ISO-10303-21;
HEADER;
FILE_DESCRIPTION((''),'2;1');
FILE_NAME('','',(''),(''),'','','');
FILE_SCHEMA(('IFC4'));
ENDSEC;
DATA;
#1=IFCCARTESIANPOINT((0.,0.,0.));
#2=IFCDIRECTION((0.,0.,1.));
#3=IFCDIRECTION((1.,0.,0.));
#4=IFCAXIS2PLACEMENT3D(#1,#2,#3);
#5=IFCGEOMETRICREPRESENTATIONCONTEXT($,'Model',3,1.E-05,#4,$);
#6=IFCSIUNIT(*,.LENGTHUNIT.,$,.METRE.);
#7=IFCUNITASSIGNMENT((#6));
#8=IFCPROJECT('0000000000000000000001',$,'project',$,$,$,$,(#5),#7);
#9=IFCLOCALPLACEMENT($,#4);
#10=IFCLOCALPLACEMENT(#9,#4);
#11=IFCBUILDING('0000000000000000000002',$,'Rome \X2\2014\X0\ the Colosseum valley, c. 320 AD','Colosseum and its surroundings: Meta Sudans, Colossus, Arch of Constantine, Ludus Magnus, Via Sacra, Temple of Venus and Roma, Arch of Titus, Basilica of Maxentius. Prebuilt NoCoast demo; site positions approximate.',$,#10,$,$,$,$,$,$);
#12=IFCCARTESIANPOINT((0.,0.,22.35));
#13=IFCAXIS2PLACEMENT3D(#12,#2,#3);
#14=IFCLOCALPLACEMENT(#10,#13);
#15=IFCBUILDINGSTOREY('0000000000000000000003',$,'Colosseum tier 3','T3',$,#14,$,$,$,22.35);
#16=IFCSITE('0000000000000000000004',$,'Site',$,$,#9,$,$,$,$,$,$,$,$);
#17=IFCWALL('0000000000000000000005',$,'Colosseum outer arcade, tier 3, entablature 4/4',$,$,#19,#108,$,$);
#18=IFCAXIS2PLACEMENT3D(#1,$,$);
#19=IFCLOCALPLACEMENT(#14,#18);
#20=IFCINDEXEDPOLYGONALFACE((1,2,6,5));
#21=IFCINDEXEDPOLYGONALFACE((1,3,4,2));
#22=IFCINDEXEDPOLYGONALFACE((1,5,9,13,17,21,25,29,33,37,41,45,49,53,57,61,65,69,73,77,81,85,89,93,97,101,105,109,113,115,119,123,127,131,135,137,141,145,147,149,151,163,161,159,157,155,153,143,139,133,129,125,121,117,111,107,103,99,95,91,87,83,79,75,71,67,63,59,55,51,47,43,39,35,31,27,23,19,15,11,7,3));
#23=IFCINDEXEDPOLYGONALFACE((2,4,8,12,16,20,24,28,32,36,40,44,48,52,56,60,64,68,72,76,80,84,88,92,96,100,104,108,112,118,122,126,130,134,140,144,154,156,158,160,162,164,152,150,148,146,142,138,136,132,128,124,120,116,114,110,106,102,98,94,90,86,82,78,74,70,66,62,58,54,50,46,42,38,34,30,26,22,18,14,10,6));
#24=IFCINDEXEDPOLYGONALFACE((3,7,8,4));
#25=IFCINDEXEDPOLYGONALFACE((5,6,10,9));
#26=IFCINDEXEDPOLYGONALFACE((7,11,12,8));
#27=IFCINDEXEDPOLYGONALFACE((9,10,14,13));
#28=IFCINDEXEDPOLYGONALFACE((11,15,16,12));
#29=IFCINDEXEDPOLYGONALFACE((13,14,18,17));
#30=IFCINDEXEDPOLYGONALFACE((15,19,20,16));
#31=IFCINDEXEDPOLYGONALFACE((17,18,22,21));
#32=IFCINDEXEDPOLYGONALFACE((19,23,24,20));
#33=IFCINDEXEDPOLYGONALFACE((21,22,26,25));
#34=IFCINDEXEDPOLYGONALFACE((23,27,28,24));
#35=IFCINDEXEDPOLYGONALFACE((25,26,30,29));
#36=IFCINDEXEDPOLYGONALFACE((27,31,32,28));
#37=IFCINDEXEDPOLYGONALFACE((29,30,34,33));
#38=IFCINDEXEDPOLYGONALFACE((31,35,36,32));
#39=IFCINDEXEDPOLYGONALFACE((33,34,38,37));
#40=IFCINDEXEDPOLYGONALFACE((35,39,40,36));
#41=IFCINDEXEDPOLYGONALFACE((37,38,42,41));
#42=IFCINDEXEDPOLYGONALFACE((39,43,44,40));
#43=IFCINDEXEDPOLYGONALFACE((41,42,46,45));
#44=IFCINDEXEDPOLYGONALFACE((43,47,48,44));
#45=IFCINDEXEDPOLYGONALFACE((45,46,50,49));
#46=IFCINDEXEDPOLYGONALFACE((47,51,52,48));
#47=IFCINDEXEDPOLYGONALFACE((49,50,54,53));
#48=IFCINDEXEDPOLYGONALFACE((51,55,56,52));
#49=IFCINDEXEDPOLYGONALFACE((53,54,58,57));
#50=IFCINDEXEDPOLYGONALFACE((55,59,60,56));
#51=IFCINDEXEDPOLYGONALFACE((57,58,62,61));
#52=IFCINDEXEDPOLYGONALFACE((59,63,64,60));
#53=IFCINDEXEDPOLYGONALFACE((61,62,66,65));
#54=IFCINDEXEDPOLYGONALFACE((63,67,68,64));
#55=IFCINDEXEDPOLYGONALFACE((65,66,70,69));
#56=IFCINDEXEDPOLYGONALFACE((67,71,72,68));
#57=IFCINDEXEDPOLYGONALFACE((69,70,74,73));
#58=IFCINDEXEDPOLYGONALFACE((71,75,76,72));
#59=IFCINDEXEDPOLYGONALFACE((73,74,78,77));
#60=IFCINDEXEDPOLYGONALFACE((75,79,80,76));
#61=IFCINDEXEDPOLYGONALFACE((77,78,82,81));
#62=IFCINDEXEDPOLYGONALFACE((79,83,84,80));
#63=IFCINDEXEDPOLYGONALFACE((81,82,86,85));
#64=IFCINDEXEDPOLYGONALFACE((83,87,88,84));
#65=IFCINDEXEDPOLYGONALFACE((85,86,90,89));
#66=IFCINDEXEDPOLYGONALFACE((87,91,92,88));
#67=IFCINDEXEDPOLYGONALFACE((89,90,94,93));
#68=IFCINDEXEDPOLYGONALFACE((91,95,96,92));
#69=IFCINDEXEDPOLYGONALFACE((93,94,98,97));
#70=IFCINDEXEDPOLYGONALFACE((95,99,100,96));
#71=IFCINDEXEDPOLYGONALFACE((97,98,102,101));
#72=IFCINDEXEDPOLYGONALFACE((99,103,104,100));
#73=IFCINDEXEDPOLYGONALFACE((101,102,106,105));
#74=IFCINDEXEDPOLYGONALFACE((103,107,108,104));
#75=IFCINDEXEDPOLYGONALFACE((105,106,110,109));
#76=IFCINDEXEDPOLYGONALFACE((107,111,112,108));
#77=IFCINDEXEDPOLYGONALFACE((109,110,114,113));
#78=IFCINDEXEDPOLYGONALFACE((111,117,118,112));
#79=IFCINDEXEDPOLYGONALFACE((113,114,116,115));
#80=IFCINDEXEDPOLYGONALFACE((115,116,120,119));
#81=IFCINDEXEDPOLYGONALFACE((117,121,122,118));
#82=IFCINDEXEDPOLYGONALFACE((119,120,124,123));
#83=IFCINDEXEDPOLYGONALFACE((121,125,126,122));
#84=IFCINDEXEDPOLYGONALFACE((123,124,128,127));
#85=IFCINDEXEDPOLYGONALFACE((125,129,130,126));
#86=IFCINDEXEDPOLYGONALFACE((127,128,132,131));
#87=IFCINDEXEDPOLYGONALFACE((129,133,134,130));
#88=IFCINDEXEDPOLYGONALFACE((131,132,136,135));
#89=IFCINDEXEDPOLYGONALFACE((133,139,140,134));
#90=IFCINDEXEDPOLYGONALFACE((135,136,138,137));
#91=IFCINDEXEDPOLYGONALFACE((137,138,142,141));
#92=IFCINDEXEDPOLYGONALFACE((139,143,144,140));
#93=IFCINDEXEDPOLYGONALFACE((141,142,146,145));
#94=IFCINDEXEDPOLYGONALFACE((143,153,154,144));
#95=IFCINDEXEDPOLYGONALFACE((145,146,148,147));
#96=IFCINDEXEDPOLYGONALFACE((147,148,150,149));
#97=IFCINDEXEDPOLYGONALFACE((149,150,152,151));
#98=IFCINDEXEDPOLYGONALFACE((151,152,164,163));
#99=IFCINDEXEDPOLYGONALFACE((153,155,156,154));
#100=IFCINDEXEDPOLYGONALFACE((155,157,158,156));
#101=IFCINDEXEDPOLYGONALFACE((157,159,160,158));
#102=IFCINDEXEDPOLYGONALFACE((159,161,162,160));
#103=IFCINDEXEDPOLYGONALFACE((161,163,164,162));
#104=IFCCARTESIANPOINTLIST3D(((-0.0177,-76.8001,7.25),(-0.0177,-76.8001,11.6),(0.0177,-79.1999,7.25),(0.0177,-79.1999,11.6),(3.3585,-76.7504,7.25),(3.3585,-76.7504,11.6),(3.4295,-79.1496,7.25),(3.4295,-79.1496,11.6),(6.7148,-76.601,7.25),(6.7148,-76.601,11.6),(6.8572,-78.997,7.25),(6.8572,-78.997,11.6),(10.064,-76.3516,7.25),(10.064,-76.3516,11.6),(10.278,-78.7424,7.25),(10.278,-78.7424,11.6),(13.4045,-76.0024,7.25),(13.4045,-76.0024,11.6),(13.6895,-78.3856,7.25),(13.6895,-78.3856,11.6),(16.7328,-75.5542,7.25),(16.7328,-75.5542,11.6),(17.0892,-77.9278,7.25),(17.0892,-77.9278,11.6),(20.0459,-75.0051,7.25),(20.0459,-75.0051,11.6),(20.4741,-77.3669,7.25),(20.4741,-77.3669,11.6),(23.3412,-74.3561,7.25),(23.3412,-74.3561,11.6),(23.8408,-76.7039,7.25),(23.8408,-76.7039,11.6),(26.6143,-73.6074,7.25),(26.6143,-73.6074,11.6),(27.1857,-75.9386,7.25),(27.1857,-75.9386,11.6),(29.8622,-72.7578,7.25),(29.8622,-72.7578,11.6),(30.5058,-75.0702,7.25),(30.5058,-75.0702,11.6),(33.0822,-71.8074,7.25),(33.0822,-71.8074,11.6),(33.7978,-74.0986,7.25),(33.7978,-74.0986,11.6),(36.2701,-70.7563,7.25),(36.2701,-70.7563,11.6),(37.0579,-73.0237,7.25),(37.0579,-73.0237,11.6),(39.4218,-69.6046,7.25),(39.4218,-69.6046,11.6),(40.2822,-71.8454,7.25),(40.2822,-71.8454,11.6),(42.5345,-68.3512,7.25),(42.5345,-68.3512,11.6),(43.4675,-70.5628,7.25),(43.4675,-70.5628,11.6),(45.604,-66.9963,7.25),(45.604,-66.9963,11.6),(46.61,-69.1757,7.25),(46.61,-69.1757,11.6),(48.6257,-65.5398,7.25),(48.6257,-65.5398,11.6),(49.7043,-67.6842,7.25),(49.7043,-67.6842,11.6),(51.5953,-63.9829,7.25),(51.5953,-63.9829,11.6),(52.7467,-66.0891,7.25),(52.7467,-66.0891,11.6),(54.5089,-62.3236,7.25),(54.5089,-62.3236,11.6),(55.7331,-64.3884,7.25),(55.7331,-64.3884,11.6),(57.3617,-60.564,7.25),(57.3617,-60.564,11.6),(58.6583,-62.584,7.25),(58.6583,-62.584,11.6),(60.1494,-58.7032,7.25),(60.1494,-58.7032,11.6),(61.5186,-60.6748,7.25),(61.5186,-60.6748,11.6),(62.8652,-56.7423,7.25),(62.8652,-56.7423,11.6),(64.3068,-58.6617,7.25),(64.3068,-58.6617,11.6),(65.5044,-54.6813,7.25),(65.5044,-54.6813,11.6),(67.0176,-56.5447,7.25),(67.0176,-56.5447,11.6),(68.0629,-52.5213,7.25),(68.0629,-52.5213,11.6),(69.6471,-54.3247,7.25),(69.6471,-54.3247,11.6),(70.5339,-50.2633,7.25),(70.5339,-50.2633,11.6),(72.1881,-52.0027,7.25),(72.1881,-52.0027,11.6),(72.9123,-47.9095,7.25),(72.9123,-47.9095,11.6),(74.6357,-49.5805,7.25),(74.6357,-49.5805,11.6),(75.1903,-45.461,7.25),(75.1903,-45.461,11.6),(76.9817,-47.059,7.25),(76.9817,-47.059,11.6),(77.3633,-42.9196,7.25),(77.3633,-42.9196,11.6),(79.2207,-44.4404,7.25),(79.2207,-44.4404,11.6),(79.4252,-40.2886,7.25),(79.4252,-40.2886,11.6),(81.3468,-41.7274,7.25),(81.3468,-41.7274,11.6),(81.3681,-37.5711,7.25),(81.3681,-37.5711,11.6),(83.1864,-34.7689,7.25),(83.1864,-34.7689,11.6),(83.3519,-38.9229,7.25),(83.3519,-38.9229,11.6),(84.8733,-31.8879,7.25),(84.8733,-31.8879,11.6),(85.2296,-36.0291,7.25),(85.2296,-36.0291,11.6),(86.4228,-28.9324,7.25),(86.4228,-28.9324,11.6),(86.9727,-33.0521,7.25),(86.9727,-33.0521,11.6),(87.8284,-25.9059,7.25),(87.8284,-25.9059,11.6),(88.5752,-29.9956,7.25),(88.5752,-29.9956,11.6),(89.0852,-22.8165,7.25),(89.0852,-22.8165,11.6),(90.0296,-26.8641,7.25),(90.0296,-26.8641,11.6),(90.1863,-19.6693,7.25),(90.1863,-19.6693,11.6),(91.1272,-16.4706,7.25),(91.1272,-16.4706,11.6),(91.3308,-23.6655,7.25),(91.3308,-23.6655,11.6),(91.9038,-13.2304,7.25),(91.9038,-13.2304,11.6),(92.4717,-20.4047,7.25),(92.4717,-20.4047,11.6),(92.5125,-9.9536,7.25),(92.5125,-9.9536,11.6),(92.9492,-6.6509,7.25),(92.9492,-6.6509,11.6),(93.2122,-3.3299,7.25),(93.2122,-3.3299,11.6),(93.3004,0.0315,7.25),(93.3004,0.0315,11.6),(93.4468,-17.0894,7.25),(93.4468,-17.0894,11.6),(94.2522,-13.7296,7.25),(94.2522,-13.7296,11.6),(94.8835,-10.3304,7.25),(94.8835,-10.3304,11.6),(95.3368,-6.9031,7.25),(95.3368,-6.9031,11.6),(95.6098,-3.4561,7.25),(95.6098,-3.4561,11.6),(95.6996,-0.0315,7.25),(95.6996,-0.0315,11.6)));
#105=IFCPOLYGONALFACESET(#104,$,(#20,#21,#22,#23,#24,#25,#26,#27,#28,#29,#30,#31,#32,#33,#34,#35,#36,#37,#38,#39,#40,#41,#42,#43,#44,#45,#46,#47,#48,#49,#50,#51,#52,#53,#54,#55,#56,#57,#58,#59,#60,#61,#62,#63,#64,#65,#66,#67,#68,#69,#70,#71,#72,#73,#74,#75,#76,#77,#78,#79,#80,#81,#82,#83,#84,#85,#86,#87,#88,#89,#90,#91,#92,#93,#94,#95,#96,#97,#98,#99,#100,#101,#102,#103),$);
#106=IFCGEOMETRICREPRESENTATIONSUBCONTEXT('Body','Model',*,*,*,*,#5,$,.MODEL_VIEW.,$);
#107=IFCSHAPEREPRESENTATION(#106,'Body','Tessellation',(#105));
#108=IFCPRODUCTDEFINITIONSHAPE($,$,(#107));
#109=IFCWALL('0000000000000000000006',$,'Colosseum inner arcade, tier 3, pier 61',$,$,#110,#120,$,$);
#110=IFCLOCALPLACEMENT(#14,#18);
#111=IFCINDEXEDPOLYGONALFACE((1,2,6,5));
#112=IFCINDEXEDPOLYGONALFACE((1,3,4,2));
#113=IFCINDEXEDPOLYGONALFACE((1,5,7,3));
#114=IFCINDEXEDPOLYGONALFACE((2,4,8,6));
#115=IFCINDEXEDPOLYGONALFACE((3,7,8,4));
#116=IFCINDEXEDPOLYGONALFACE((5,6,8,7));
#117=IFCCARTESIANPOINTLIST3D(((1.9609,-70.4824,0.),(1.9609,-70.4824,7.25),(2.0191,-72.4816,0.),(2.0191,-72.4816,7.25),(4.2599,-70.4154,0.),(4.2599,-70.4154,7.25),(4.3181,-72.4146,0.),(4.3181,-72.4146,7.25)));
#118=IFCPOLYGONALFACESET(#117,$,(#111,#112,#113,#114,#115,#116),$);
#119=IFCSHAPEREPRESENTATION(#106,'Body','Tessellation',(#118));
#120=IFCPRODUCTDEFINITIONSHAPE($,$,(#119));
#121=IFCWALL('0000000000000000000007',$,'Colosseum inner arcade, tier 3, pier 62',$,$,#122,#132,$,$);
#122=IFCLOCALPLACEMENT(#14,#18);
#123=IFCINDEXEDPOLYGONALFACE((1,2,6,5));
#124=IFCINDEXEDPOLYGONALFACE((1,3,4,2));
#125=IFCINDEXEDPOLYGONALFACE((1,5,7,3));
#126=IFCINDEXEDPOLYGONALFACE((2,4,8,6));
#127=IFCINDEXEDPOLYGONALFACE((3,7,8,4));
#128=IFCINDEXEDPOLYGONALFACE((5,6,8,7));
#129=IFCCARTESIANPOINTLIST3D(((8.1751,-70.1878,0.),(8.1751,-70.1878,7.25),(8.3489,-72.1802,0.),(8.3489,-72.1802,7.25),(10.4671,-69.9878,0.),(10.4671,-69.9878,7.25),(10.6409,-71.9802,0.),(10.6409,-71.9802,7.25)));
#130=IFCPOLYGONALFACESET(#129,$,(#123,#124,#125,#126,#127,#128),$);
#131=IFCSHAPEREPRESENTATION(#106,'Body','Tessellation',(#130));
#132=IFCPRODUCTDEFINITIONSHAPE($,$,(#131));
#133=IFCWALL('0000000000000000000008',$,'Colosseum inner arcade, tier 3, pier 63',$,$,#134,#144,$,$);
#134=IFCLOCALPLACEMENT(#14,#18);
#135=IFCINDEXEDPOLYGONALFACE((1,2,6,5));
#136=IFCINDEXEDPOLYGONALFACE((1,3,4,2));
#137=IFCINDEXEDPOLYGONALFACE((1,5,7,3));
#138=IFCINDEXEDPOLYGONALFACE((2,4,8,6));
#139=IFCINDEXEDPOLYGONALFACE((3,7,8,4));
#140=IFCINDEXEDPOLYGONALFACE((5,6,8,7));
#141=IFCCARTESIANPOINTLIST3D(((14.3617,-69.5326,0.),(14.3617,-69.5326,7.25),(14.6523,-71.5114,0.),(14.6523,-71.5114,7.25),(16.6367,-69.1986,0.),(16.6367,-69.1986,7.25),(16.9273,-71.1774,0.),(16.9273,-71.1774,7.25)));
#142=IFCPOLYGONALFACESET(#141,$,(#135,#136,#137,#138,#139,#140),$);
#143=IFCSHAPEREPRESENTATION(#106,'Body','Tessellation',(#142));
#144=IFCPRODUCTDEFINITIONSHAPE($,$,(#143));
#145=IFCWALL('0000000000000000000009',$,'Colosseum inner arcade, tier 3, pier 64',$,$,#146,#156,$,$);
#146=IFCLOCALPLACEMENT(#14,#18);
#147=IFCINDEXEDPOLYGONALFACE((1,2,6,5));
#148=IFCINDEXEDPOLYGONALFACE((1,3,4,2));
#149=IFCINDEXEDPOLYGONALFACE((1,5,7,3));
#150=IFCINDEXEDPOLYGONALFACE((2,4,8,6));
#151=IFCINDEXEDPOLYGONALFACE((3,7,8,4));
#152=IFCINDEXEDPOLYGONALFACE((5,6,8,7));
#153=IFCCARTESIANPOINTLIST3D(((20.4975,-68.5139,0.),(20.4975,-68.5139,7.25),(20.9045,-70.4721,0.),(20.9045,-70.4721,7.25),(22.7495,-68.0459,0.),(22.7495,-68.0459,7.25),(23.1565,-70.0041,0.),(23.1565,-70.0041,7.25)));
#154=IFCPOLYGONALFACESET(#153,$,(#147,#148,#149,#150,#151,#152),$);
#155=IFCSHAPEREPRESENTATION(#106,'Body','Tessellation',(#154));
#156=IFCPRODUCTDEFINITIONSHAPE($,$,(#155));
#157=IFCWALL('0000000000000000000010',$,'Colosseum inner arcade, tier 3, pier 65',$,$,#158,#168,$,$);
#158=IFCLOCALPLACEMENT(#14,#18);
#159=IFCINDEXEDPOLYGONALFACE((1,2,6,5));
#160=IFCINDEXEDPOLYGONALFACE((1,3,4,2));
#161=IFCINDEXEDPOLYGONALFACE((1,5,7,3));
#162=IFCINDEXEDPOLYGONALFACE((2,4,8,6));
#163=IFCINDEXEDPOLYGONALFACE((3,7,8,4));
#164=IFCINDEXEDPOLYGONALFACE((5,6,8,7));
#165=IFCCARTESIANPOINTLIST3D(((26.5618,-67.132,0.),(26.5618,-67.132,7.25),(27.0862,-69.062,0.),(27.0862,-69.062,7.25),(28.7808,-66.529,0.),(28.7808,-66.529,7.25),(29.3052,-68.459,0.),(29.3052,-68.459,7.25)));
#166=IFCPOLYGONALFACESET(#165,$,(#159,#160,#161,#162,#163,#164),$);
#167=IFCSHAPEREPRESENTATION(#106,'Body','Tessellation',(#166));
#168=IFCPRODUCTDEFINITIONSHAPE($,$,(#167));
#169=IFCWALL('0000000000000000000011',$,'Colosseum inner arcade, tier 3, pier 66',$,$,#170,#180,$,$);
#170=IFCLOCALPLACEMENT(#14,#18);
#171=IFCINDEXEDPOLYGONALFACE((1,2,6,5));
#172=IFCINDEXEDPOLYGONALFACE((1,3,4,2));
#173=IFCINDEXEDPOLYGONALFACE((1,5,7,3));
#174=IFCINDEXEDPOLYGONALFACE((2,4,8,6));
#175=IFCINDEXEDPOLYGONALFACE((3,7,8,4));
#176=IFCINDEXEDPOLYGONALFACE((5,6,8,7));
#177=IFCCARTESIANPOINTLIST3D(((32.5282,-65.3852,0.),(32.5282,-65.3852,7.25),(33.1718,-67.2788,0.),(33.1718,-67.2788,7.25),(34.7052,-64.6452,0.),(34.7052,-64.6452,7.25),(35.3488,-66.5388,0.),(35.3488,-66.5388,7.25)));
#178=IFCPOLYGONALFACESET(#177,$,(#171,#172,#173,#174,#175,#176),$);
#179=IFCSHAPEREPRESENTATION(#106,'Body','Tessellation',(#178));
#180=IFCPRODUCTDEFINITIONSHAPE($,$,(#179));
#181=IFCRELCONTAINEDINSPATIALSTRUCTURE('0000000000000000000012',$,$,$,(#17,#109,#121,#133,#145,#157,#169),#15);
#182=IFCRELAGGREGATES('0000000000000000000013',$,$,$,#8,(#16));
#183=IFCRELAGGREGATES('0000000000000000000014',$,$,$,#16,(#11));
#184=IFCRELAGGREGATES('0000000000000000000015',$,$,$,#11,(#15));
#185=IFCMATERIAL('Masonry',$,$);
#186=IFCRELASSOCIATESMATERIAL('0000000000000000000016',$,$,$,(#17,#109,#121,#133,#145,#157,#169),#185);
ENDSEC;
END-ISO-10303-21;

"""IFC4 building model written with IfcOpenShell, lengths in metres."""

from ifc_helpers import new_model, si_unit, frame, origin_with_axes, place, context, subcontext, project, spatial, polyline, indexed_curve, outline, extrude, material, element, save


model = new_model("IFC4")

# Units and contexts
model_context = context("Model", 3, precision=1e-05, world=origin_with_axes())
body_context = subcontext(model_context, "Body", "Model", "MODEL_VIEW")
ifc_project = project(units=[si_unit("LENGTHUNIT", "METRE")], contexts=[model_context])

# Site, building, storey
site_placement = place(None, origin_with_axes())
site = spatial("IfcSite", under=ifc_project, at=site_placement, Name="Site")
building_placement = place(site_placement, origin_with_axes())
building = spatial("IfcBuilding", under=site, at=building_placement, Name="Rome — the Colosseum valley, c. 320 AD", Description="Colosseum and its surroundings: Meta Sudans, Colossus, Arch of Constantine, Ludus Magnus, Via Sacra, Temple of Venus and Roma, Arch of Titus, Basilica of Maxentius. Prebuilt NoCoast demo; site positions approximate.")
storey_placement = place(building_placement, frame((0.0, 0.0, 22.35), z_axis=(0.0, 0.0, 1.0), x_axis=(1.0, 0.0, 0.0)))
storey = spatial("IfcBuildingStorey", under=building, at=storey_placement, Name="Colosseum tier 3", Description="T3", Elevation=22.35)

# Walls
ifc_material_1 = material(Name="Masonry")
wall_1_placement = place(storey_placement, frame((0.0, 0.0, 7.25), z_axis=(0.0, 0.0, 1.0), x_axis=(1.0, 0.0, 0.0)))
element("IfcWall", 1, at=wall_1_placement, inside=storey, material=ifc_material_1, Name="Colosseum outer arcade, tier 3, entablature 4/4", context=body_context, shape_type="SweptSolid", body=[
    extrude(outline(polyline([(3.3585, -76.7504), (6.7148, -76.601), (10.064, -76.3516), (13.4045, -76.0024), (16.7328, -75.5542), (20.0459, -75.0051), (23.3412, -74.3561), (26.6143, -73.6074), (29.8622, -72.7578), (33.0822, -71.8074), (36.2701, -70.7563), (39.4218, -69.6046), (42.5345, -68.3512), (45.604, -66.9963), (48.6257, -65.5398), (51.5953, -63.9829), (54.5089, -62.3236), (57.3617, -60.564), (60.1494, -58.7032), (62.8652, -56.7423), (65.5044, -54.6813), (68.0629, -52.5213), (70.5339, -50.2633), (72.9123, -47.9095), (75.1903, -45.461), (77.3633, -42.9196), (79.4252, -40.2886), (81.3681, -37.5711), (83.1864, -34.7689), (84.8733, -31.8879), (86.4228, -28.9324), (87.8284, -25.9059), (89.0852, -22.8165), (90.1863, -19.6693), (91.1272, -16.4706), (91.9038, -13.2304), (92.5125, -9.9536), (92.9492, -6.6509), (93.2122, -3.3299), (93.3004, 0.0315), (95.6996, -0.0315), (95.6098, -3.4561), (95.3368, -6.9031), (94.8835, -10.3304), (94.2522, -13.7296), (93.4468, -17.0894), (92.4717, -20.4047), (91.3308, -23.6655), (90.0296, -26.8641), (88.5752, -29.9956), (86.9727, -33.0521), (85.2296, -36.0291), (83.3519, -38.9229), (81.3468, -41.7274), (79.2207, -44.4404), (76.9817, -47.059), (74.6357, -49.5805), (72.1881, -52.0027), (69.6471, -54.3247), (67.0176, -56.5447), (64.3068, -58.6617), (61.5186, -60.6748), (58.6583, -62.584), (55.7331, -64.3884), (52.7467, -66.0891), (49.7043, -67.6842), (46.61, -69.1757), (43.4675, -70.5628), (40.2822, -71.8454), (37.0579, -73.0237), (33.7978, -74.0986), (30.5058, -75.0702), (27.1857, -75.9386), (23.8408, -76.7039), (20.4741, -77.3669), (17.0892, -77.9278), (13.6895, -78.3856), (10.278, -78.7424), (6.8572, -78.997), (3.4295, -79.1496), (0.0177, -79.1999), (-0.0177, -76.8001), (3.3585, -76.7504)])), origin_with_axes(), (0.0, 0.0, 1.0), 4.35),
])
wall_2_placement = place(storey_placement, frame((1.99, -71.482, 0.0), z_axis=(0.0, 0.0, 1.0), x_axis=(0.999576, 0.029131, 0.0)))
element("IfcWall", 2, at=wall_2_placement, inside=storey, material=ifc_material_1, Name="Colosseum inner arcade, tier 3, pier 61", context=body_context, shape_type="SweptSolid", body=[
    extrude(outline(indexed_curve([(0.0, 0.0), (0.0, 2.0), (2.3, 2.0), (2.3, 0.0), (0.0, 0.0)], self_intersect=False)), frame((0.0, -1.0, 0.0), z_axis=(0.0, 0.0, 1.0), x_axis=(1.0, 0.0, 0.0)), (0.0, 0.0, 1.0), 7.25),
])
wall_3_placement = place(storey_placement, frame((8.262, -71.184, 0.0), z_axis=(0.0, 0.0, 1.0), x_axis=(0.996214, 0.08693, 0.0)))
element("IfcWall", 3, at=wall_3_placement, inside=storey, material=ifc_material_1, Name="Colosseum inner arcade, tier 3, pier 62", context=body_context, shape_type="SweptSolid", body=[
    extrude(outline(indexed_curve([(0.0, 0.0), (0.0, 2.0), (2.3007, 2.0), (2.3007, 0.0), (0.0, 0.0)], self_intersect=False)), frame((0.0, -1.0, 0.0), z_axis=(0.0, 0.0, 1.0), x_axis=(1.0, 0.0, 0.0)), (0.0, 0.0, 1.0), 7.25),
])
wall_4_placement = place(storey_placement, frame((14.507, -70.522, 0.0), z_axis=(0.0, 0.0, 1.0), x_axis=(0.989394, 0.145256, 0.0)))
element("IfcWall", 4, at=wall_4_placement, inside=storey, material=ifc_material_1, Name="Colosseum inner arcade, tier 3, pier 63", context=body_context, shape_type="SweptSolid", body=[
    extrude(outline(indexed_curve([(0.0, 0.0), (0.0, 2.0), (2.2994, 2.0), (2.2994, 0.0), (0.0, 0.0)], self_intersect=False)), frame((0.0, -1.0, 0.0), z_axis=(0.0, 0.0, 1.0), x_axis=(1.0, 0.0, 0.0)), (0.0, 0.0, 1.0), 7.25),
])
wall_5_placement = place(storey_placement, frame((20.701, -69.493, 0.0), z_axis=(0.0, 0.0, 1.0), x_axis=(0.979082, 0.203468, 0.0)))
element("IfcWall", 5, at=wall_5_placement, inside=storey, material=ifc_material_1, Name="Colosseum inner arcade, tier 3, pier 64", context=body_context, shape_type="SweptSolid", body=[
    extrude(outline(indexed_curve([(0.0, 0.0), (0.0, 2.0), (2.3001, 2.0), (2.3001, 0.0), (0.0, 0.0)], self_intersect=False)), frame((0.0, -1.0, 0.0), z_axis=(0.0, 0.0, 1.0), x_axis=(1.0, 0.0, 0.0)), (0.0, 0.0, 1.0), 7.25),
])
wall_6_placement = place(storey_placement, frame((26.824, -68.097, 0.0), z_axis=(0.0, 0.0, 1.0), x_axis=(0.965004, 0.262234, 0.0)))
element("IfcWall", 6, at=wall_6_placement, inside=storey, material=ifc_material_1, Name="Colosseum inner arcade, tier 3, pier 65", context=body_context, shape_type="SweptSolid", body=[
    extrude(outline(indexed_curve([(0.0, 0.0), (0.0, 2.0), (2.2995, 2.0), (2.2995, 0.0), (0.0, 0.0)], self_intersect=False)), frame((0.0, -1.0, 0.0), z_axis=(0.0, 0.0, 1.0), x_axis=(1.0, 0.0, 0.0)), (0.0, 0.0, 1.0), 7.25),
])
wall_7_placement = place(storey_placement, frame((32.85, -66.332, 0.0), z_axis=(0.0, 0.0, 1.0), x_axis=(0.946797, 0.321833, 0.0)))
element("IfcWall", 7, at=wall_7_placement, inside=storey, material=ifc_material_1, Name="Colosseum inner arcade, tier 3, pier 66", context=body_context, shape_type="SweptSolid", body=[
    extrude(outline(indexed_curve([(0.0, 0.0), (0.0, 2.0), (2.2993, 2.0), (2.2993, 0.0), (0.0, 0.0)], self_intersect=False)), frame((0.0, -1.0, 0.0), z_axis=(0.0, 0.0, 1.0), x_axis=(1.0, 0.0, 0.0)), (0.0, 0.0, 1.0), 7.25),
])

save(model, "model.ifc")
